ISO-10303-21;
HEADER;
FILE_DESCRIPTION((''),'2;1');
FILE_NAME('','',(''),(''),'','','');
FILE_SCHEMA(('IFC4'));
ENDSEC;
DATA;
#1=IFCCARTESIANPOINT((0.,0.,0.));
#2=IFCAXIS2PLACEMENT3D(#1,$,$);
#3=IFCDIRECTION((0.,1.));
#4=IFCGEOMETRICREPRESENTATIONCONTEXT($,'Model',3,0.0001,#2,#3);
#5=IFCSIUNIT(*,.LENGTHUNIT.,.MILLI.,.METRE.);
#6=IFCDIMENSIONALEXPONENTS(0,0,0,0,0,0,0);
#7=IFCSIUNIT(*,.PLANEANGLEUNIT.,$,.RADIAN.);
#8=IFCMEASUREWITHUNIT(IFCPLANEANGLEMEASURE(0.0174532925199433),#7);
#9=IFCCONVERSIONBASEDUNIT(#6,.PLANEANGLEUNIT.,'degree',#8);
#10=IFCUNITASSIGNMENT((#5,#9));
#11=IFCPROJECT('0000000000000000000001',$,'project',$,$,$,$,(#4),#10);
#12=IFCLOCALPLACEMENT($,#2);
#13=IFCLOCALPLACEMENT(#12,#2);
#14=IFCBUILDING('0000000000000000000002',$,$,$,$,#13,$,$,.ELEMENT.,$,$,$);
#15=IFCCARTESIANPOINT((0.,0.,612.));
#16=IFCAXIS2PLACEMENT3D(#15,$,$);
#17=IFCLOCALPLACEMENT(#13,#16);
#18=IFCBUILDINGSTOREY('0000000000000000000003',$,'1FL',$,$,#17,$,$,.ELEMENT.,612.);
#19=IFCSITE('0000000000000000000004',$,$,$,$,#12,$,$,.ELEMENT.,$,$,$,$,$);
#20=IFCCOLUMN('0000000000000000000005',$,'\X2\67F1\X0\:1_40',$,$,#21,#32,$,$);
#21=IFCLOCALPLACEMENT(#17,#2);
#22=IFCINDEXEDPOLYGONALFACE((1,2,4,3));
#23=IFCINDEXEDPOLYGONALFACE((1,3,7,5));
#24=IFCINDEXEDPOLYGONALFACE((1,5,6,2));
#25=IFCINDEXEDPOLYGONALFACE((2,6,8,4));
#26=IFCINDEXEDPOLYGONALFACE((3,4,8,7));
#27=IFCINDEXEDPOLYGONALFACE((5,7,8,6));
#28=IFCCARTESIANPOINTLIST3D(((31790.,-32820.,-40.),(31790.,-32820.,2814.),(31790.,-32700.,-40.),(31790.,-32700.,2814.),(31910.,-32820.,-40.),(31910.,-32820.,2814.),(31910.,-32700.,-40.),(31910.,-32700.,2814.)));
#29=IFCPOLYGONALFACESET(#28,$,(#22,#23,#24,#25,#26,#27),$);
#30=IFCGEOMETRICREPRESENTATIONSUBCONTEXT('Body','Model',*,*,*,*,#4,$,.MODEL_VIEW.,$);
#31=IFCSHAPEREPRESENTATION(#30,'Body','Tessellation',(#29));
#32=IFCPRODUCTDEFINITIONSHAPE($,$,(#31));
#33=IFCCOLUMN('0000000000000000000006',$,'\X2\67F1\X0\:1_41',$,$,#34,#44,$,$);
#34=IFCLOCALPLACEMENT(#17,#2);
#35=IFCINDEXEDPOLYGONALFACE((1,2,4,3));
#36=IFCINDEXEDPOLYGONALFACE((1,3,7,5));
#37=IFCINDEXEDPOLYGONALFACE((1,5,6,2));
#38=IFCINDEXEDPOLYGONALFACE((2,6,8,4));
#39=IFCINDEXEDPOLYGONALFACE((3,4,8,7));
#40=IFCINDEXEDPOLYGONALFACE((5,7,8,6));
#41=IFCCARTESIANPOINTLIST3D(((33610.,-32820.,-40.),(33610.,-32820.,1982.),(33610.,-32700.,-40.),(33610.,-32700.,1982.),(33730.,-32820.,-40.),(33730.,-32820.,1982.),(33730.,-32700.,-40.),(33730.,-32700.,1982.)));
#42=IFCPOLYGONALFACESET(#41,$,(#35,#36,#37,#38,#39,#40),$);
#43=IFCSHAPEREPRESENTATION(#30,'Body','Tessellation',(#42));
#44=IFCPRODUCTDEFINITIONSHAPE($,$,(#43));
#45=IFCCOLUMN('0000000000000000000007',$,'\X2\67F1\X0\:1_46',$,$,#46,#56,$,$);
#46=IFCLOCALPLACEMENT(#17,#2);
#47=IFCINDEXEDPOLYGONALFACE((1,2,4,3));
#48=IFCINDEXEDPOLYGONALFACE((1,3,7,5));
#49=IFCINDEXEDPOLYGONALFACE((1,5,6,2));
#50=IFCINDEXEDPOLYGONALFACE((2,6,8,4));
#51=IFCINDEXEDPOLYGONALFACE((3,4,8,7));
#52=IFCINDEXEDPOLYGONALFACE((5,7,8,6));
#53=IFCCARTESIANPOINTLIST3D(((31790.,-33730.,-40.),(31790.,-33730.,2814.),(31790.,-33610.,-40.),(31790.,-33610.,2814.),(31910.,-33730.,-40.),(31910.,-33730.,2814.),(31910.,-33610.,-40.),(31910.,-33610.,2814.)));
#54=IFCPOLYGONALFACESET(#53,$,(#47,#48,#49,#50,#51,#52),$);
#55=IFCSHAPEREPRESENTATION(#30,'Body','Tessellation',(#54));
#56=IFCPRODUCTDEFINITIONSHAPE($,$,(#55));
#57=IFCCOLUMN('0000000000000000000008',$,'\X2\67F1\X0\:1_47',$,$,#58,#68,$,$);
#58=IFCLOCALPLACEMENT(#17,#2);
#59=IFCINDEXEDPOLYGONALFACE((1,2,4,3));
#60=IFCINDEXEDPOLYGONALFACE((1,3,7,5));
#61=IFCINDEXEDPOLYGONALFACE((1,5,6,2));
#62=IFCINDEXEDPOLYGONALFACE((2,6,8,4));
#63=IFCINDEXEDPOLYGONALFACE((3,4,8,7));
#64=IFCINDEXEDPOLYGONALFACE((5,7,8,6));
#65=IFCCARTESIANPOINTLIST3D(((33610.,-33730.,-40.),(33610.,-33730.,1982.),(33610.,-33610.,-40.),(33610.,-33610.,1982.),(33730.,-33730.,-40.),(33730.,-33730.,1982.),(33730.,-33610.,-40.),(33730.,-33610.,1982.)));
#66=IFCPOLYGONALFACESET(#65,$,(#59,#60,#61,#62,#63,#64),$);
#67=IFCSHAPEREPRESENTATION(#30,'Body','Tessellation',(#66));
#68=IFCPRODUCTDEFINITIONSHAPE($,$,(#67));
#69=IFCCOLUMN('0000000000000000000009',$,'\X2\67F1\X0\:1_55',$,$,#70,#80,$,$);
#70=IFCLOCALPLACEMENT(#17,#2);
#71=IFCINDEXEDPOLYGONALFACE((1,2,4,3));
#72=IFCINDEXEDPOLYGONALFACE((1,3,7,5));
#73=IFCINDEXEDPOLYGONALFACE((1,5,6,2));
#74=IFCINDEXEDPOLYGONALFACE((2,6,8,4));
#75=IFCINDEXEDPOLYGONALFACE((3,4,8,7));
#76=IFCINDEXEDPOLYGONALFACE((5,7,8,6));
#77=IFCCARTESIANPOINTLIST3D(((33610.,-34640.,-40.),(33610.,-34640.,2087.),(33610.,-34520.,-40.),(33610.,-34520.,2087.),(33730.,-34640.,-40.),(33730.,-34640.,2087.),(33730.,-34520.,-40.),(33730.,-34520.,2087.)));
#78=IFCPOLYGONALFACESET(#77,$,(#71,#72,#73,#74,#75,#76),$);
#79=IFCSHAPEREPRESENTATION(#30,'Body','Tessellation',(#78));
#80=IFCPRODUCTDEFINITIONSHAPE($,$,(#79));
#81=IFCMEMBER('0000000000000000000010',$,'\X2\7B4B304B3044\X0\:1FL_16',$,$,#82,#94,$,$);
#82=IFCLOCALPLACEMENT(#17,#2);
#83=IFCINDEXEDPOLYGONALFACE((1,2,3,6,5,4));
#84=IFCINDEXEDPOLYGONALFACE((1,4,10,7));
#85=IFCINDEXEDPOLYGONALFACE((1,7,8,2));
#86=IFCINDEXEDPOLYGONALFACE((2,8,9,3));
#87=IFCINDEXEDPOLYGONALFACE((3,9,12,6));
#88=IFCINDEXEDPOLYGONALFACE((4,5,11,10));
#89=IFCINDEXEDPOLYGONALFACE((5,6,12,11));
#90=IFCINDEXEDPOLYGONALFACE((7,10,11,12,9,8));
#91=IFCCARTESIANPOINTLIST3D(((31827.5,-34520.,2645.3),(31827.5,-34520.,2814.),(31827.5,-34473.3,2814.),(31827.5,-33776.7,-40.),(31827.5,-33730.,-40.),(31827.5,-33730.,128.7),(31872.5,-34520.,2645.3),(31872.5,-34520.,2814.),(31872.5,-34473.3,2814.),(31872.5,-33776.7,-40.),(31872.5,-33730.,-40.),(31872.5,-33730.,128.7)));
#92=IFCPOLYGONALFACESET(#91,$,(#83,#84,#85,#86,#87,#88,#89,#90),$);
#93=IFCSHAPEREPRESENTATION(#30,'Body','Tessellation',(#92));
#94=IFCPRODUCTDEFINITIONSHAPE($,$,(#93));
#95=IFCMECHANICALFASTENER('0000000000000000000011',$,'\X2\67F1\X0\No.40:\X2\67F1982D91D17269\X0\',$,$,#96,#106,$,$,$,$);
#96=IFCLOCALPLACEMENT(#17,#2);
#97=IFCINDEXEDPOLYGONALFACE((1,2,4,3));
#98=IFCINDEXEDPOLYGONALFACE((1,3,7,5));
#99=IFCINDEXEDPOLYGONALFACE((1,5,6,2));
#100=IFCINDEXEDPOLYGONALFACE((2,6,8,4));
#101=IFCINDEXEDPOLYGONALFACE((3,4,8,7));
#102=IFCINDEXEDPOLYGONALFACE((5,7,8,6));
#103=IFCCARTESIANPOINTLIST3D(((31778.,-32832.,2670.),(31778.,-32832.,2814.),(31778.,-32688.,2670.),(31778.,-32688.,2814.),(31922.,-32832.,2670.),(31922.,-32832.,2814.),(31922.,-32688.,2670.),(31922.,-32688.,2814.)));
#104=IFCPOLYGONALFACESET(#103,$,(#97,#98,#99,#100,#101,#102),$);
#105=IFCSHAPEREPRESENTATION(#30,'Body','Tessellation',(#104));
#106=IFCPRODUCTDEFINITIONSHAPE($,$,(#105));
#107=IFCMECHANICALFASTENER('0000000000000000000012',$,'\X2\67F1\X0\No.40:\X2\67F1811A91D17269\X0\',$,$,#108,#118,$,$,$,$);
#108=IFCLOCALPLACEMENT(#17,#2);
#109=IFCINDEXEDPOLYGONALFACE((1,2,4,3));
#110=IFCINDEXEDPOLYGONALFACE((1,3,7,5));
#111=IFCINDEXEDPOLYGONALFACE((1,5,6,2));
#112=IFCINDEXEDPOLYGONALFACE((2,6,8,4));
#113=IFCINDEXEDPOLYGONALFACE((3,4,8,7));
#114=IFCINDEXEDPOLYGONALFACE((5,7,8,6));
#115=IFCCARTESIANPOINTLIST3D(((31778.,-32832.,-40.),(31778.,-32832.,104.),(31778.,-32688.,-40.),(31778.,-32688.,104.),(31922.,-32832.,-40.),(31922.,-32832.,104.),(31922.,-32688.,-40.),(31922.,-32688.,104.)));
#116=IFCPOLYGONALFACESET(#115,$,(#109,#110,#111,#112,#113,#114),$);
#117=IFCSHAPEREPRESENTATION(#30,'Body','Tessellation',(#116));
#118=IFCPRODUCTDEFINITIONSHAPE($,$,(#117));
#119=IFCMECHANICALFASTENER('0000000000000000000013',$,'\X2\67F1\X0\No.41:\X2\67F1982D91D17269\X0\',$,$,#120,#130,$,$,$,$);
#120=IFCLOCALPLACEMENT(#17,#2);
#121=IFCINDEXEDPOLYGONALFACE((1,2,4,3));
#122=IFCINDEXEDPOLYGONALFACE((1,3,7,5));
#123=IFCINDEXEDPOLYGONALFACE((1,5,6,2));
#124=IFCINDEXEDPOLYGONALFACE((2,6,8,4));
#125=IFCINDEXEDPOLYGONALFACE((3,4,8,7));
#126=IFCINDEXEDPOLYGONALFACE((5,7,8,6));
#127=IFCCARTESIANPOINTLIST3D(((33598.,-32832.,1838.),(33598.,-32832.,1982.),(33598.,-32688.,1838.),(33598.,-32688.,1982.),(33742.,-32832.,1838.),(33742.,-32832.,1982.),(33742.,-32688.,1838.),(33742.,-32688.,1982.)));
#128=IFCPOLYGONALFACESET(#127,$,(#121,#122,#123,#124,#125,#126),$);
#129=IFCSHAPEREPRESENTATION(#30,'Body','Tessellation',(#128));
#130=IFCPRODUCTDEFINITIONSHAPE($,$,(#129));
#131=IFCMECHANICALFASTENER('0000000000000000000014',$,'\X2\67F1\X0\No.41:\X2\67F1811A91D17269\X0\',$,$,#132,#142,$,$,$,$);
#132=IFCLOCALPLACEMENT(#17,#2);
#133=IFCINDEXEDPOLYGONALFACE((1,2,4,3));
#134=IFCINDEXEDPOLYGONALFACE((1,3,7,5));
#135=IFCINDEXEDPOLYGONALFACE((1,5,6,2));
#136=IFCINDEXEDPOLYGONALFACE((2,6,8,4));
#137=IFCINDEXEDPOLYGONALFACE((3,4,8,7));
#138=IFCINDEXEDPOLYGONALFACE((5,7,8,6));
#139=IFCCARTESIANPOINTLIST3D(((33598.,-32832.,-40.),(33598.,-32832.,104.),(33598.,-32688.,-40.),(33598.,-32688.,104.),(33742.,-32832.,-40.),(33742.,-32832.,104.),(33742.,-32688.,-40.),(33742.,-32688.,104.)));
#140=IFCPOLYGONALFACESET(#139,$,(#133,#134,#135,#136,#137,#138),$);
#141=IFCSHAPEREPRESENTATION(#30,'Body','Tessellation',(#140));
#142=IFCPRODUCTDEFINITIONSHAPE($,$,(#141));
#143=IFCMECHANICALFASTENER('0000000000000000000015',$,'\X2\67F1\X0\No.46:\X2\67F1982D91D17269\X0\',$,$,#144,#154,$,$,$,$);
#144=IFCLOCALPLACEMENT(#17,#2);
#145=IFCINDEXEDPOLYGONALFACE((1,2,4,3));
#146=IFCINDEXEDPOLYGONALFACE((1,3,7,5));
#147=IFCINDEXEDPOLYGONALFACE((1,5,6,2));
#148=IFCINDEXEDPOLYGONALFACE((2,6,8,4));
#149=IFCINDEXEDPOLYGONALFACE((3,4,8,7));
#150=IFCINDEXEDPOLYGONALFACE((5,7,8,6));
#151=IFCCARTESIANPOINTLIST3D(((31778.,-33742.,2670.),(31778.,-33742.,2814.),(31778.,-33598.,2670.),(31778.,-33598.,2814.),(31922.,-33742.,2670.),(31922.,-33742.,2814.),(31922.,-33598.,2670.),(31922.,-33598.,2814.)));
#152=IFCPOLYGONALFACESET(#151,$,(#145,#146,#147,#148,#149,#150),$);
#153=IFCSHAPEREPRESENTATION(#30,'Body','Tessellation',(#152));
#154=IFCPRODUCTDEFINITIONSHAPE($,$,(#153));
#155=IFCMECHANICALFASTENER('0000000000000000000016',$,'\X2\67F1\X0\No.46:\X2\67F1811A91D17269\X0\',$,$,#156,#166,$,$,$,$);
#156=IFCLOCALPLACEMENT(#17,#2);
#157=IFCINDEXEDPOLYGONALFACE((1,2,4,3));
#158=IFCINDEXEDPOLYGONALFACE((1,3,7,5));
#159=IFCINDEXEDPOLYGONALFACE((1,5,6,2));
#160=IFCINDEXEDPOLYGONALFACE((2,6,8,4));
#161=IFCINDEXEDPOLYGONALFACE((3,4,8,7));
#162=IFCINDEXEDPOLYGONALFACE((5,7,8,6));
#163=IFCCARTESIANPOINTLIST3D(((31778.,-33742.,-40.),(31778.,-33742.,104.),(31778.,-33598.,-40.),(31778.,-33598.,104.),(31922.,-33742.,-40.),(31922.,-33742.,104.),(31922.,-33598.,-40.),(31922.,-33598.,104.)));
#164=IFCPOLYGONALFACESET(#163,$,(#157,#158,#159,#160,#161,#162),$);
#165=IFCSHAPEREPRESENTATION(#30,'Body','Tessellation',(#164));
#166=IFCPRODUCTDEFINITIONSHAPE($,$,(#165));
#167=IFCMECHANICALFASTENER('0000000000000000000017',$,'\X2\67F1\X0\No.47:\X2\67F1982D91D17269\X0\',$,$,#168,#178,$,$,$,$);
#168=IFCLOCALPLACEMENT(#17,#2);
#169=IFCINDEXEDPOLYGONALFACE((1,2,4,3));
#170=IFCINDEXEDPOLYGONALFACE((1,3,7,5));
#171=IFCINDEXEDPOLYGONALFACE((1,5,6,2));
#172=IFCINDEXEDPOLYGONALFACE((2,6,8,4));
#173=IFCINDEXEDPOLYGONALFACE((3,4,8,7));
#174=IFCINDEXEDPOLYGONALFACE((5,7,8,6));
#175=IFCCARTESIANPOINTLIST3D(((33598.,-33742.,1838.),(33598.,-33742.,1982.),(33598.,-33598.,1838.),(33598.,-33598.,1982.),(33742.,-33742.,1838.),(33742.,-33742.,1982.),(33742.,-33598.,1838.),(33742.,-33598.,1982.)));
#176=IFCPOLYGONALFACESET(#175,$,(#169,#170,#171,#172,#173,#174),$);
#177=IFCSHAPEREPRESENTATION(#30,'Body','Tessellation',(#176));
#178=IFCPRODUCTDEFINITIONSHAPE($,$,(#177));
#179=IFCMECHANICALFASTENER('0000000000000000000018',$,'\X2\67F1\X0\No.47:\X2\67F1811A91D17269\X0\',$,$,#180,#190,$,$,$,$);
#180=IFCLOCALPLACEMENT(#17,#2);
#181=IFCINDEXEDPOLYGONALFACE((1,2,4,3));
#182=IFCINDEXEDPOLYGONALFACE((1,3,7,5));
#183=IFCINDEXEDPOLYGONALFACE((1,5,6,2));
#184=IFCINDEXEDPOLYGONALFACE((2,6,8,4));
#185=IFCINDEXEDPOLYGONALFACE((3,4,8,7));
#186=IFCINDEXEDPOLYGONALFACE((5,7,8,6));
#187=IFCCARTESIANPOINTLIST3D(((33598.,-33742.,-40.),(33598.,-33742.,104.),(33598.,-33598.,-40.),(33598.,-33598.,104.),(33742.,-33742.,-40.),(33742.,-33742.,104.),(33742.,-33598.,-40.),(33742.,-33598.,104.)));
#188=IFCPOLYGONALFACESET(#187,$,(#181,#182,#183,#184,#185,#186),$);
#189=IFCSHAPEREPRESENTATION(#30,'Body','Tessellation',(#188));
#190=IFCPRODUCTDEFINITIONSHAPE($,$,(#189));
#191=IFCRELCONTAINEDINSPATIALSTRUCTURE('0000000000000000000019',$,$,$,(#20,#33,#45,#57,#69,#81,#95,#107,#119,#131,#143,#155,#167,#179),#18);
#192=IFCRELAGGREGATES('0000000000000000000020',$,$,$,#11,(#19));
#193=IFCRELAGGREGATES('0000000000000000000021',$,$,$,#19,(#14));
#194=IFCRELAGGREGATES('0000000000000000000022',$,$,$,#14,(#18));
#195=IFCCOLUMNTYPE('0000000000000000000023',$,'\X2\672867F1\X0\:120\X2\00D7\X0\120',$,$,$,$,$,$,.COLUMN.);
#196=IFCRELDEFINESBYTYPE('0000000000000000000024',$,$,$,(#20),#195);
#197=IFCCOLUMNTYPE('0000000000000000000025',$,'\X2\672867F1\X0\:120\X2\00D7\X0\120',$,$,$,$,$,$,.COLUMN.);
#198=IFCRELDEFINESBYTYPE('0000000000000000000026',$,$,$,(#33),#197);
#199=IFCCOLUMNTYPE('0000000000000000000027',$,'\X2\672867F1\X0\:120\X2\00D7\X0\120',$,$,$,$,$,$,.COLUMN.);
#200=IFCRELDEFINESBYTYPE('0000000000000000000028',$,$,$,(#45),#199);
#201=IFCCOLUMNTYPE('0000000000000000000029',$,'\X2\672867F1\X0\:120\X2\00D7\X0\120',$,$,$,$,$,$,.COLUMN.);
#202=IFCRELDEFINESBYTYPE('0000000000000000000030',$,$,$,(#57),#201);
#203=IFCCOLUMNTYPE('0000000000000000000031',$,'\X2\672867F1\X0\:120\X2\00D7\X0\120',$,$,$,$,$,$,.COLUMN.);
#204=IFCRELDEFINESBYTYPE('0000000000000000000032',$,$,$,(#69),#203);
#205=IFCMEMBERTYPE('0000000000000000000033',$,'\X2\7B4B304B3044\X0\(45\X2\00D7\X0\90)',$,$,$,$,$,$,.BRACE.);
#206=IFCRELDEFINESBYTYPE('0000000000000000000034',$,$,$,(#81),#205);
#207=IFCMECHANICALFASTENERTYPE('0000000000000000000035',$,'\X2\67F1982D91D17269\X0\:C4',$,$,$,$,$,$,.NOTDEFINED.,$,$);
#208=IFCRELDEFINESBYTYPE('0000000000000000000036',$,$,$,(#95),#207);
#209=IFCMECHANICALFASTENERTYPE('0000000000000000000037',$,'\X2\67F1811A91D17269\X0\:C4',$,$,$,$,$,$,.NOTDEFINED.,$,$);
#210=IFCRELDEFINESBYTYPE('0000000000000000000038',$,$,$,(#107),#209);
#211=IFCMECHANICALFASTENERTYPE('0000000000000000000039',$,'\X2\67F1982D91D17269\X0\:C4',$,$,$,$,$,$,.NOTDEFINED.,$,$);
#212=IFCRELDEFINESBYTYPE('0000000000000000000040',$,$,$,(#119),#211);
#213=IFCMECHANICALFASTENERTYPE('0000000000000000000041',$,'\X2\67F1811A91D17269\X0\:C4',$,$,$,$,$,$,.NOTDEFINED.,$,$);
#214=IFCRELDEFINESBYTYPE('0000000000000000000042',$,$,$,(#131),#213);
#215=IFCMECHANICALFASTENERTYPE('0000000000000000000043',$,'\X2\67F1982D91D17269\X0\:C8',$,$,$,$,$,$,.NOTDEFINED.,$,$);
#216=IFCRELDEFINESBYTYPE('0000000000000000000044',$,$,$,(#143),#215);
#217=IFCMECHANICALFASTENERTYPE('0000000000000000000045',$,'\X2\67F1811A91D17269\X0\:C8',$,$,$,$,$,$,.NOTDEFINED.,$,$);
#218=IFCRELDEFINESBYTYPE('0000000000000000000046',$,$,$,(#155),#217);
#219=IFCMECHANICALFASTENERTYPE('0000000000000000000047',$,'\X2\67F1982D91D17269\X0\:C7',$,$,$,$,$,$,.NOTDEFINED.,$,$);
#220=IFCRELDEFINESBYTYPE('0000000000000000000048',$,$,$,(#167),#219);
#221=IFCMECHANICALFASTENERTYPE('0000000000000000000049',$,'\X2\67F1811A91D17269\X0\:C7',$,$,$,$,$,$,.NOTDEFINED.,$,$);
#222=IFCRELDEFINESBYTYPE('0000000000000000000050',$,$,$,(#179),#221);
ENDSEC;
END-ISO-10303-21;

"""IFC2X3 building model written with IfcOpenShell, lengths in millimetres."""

from ifc_helpers import new_model, entity, si_unit, converted_unit, direction, frame, origin, origin_with_axes, origin_2d, place, context, subcontext, project, spatial, polyline, rectangle, outline, extrude, type_object, element, save


model = new_model("IFC2X3")

# Units and contexts
model_context = context("Model", 3, precision=0.0001, world=origin(), true_north=direction((0.0, 1.0)))
body_context = subcontext(model_context, "Body", "Model", "MODEL_VIEW")
ifc_project = project(units=[si_unit("LENGTHUNIT", "METRE", prefix="MILLI"), converted_unit("PLANEANGLEUNIT", "degree", entity("IfcPlaneAngleMeasure", 0.0174532925199433), si_unit("PLANEANGLEUNIT", "RADIAN"), dimensions=[0, 0, 0, 0, 0, 0, 0])], contexts=[model_context])

# Site, building, storey
site_placement = place(None, origin())
site = spatial("IfcSite", under=ifc_project, at=site_placement, CompositionType="ELEMENT")
building_placement = place(site_placement, origin())
building = spatial("IfcBuilding", under=site, at=building_placement, CompositionType="ELEMENT")
storey_placement = place(building_placement, frame((0.0, 0.0, 612.0)))
storey = spatial("IfcBuildingStorey", under=building, at=storey_placement, Name="1FL", CompositionType="ELEMENT", Elevation=612.0)

# Columns
column_type_1 = type_object("IfcColumnType", Name="木柱:120×120", PredefinedType="COLUMN")
column_1_placement = place(storey_placement, frame((31850.0, -32760.0, -40.0)))
element("IfcColumn", 1, at=column_1_placement, inside=storey, type_object=column_type_1, Name="柱:1_40", context=body_context, shape_type="SweptSolid", body=[
    extrude(rectangle(XDim=120.0, YDim=120.0, at=origin_2d()), origin_with_axes(), (0.0, 0.0, 1.0), 2854.0),
])
column_type_2 = type_object("IfcColumnType", Name="木柱:120×120", PredefinedType="COLUMN")
column_2_placement = place(storey_placement, frame((33670.0, -32760.0, -40.0)))
element("IfcColumn", 2, at=column_2_placement, inside=storey, type_object=column_type_2, Name="柱:1_41", context=body_context, shape_type="SweptSolid", body=[
    extrude(rectangle(XDim=120.0, YDim=120.0, at=origin_2d()), origin_with_axes(), (0.0, 0.0, 1.0), 2022.0),
])
column_type_3 = type_object("IfcColumnType", Name="木柱:120×120", PredefinedType="COLUMN")
column_3_placement = place(storey_placement, frame((31850.0, -33670.0, -40.0)))
element("IfcColumn", 3, at=column_3_placement, inside=storey, type_object=column_type_3, Name="柱:1_46", context=body_context, shape_type="SweptSolid", body=[
    extrude(rectangle(XDim=120.0, YDim=120.0, at=origin_2d()), origin_with_axes(), (0.0, 0.0, 1.0), 2854.0),
])
column_type_4 = type_object("IfcColumnType", Name="木柱:120×120", PredefinedType="COLUMN")
column_4_placement = place(storey_placement, frame((33670.0, -33670.0, -40.0)))
element("IfcColumn", 4, at=column_4_placement, inside=storey, type_object=column_type_4, Name="柱:1_47", context=body_context, shape_type="SweptSolid", body=[
    extrude(rectangle(XDim=120.0, YDim=120.0, at=origin_2d()), origin_with_axes(), (0.0, 0.0, 1.0), 2022.0),
])
column_type_5 = type_object("IfcColumnType", Name="木柱:120×120", PredefinedType="COLUMN")
column_5_placement = place(storey_placement, frame((33670.0, -34580.0, -40.0)))
element("IfcColumn", 5, at=column_5_placement, inside=storey, type_object=column_type_5, Name="柱:1_55", context=body_context, shape_type="SweptSolid", body=[
    extrude(rectangle(XDim=120.0, YDim=120.0, at=origin_2d()), origin_with_axes(), (0.0, 0.0, 1.0), 2127.0),
])

# Member
member_type = type_object("IfcMemberType", Name="筋かい(45×90)", PredefinedType="BRACE")
member_placement = place(storey_placement, frame((31850.0, -33730.0, -40.0), z_axis=(0.0, -0.266773, 0.963759), x_axis=(0.0, 0.963759, 0.266773)))
element("IfcMember", 6, at=member_placement, inside=storey, type_object=member_type, Name="筋かい:1FL_16", context=body_context, shape_type="SweptSolid", body=[
    extrude(outline(polyline([(0.0, 0.0), (12.5, -45.0), (2798.8, -45.0), (2961.3, 0.0), (2948.9, 45.0), (162.6, 45.0), (0.0, 0.0)])), frame((0.0, -22.5, 0.0), z_axis=(0.0, 1.0, 0.0), x_axis=(0.0, 0.0, 1.0)), (0.0, 0.0, 1.0), 45.0),
])

# Mechanical fasteners
mechanical_fastener_type_1 = type_object("IfcMechanicalFastenerType", Name="柱頭金物:C4")
mechanical_fastener_1_placement = place(storey_placement, frame((31850.0, -32760.0, 2670.0)))
element("IfcMechanicalFastener", 7, at=mechanical_fastener_1_placement, inside=storey, type_object=mechanical_fastener_type_1, Name="柱No.40:柱頭金物", context=body_context, shape_type="SweptSolid", body=[
    extrude(rectangle(XDim=144.0, YDim=144.0, at=origin_2d()), origin_with_axes(), (0.0, 0.0, 1.0), 144.0),
])
mechanical_fastener_type_2 = type_object("IfcMechanicalFastenerType", Name="柱脚金物:C4")
mechanical_fastener_2_placement = place(storey_placement, frame((31850.0, -32760.0, -40.0)))
element("IfcMechanicalFastener", 8, at=mechanical_fastener_2_placement, inside=storey, type_object=mechanical_fastener_type_2, Name="柱No.40:柱脚金物", context=body_context, shape_type="SweptSolid", body=[
    extrude(rectangle(XDim=144.0, YDim=144.0, at=origin_2d()), origin_with_axes(), (0.0, 0.0, 1.0), 144.0),
])
mechanical_fastener_type_3 = type_object("IfcMechanicalFastenerType", Name="柱頭金物:C4")
mechanical_fastener_3_placement = place(storey_placement, frame((33670.0, -32760.0, 1838.0)))
element("IfcMechanicalFastener", 9, at=mechanical_fastener_3_placement, inside=storey, type_object=mechanical_fastener_type_3, Name="柱No.41:柱頭金物", context=body_context, shape_type="SweptSolid", body=[
    extrude(rectangle(XDim=144.0, YDim=144.0, at=origin_2d()), origin_with_axes(), (0.0, 0.0, 1.0), 144.0),
])
mechanical_fastener_type_4 = type_object("IfcMechanicalFastenerType", Name="柱脚金物:C4")
mechanical_fastener_4_placement = place(storey_placement, frame((33670.0, -32760.0, -40.0)))
element("IfcMechanicalFastener", 10, at=mechanical_fastener_4_placement, inside=storey, type_object=mechanical_fastener_type_4, Name="柱No.41:柱脚金物", context=body_context, shape_type="SweptSolid", body=[
    extrude(rectangle(XDim=144.0, YDim=144.0, at=origin_2d()), origin_with_axes(), (0.0, 0.0, 1.0), 144.0),
])
mechanical_fastener_type_5 = type_object("IfcMechanicalFastenerType", Name="柱頭金物:C8")
mechanical_fastener_5_placement = place(storey_placement, frame((31850.0, -33670.0, 2670.0)))
element("IfcMechanicalFastener", 11, at=mechanical_fastener_5_placement, inside=storey, type_object=mechanical_fastener_type_5, Name="柱No.46:柱頭金物", context=body_context, shape_type="SweptSolid", body=[
    extrude(rectangle(XDim=144.0, YDim=144.0, at=origin_2d()), origin_with_axes(), (0.0, 0.0, 1.0), 144.0),
])
mechanical_fastener_type_6 = type_object("IfcMechanicalFastenerType", Name="柱脚金物:C8")
mechanical_fastener_6_placement = place(storey_placement, frame((31850.0, -33670.0, -40.0)))
element("IfcMechanicalFastener", 12, at=mechanical_fastener_6_placement, inside=storey, type_object=mechanical_fastener_type_6, Name="柱No.46:柱脚金物", context=body_context, shape_type="SweptSolid", body=[
    extrude(rectangle(XDim=144.0, YDim=144.0, at=origin_2d()), origin_with_axes(), (0.0, 0.0, 1.0), 144.0),
])
mechanical_fastener_type_7 = type_object("IfcMechanicalFastenerType", Name="柱頭金物:C7")
mechanical_fastener_7_placement = place(storey_placement, frame((33670.0, -33670.0, 1838.0)))
element("IfcMechanicalFastener", 13, at=mechanical_fastener_7_placement, inside=storey, type_object=mechanical_fastener_type_7, Name="柱No.47:柱頭金物", context=body_context, shape_type="SweptSolid", body=[
    extrude(rectangle(XDim=144.0, YDim=144.0, at=origin_2d()), origin_with_axes(), (0.0, 0.0, 1.0), 144.0),
])
mechanical_fastener_type_8 = type_object("IfcMechanicalFastenerType", Name="柱脚金物:C7")
mechanical_fastener_8_placement = place(storey_placement, frame((33670.0, -33670.0, -40.0)))
element("IfcMechanicalFastener", 14, at=mechanical_fastener_8_placement, inside=storey, type_object=mechanical_fastener_type_8, Name="柱No.47:柱脚金物", context=body_context, shape_type="SweptSolid", body=[
    extrude(rectangle(XDim=144.0, YDim=144.0, at=origin_2d()), origin_with_axes(), (0.0, 0.0, 1.0), 144.0),
])

save(model, "model.ifc")
